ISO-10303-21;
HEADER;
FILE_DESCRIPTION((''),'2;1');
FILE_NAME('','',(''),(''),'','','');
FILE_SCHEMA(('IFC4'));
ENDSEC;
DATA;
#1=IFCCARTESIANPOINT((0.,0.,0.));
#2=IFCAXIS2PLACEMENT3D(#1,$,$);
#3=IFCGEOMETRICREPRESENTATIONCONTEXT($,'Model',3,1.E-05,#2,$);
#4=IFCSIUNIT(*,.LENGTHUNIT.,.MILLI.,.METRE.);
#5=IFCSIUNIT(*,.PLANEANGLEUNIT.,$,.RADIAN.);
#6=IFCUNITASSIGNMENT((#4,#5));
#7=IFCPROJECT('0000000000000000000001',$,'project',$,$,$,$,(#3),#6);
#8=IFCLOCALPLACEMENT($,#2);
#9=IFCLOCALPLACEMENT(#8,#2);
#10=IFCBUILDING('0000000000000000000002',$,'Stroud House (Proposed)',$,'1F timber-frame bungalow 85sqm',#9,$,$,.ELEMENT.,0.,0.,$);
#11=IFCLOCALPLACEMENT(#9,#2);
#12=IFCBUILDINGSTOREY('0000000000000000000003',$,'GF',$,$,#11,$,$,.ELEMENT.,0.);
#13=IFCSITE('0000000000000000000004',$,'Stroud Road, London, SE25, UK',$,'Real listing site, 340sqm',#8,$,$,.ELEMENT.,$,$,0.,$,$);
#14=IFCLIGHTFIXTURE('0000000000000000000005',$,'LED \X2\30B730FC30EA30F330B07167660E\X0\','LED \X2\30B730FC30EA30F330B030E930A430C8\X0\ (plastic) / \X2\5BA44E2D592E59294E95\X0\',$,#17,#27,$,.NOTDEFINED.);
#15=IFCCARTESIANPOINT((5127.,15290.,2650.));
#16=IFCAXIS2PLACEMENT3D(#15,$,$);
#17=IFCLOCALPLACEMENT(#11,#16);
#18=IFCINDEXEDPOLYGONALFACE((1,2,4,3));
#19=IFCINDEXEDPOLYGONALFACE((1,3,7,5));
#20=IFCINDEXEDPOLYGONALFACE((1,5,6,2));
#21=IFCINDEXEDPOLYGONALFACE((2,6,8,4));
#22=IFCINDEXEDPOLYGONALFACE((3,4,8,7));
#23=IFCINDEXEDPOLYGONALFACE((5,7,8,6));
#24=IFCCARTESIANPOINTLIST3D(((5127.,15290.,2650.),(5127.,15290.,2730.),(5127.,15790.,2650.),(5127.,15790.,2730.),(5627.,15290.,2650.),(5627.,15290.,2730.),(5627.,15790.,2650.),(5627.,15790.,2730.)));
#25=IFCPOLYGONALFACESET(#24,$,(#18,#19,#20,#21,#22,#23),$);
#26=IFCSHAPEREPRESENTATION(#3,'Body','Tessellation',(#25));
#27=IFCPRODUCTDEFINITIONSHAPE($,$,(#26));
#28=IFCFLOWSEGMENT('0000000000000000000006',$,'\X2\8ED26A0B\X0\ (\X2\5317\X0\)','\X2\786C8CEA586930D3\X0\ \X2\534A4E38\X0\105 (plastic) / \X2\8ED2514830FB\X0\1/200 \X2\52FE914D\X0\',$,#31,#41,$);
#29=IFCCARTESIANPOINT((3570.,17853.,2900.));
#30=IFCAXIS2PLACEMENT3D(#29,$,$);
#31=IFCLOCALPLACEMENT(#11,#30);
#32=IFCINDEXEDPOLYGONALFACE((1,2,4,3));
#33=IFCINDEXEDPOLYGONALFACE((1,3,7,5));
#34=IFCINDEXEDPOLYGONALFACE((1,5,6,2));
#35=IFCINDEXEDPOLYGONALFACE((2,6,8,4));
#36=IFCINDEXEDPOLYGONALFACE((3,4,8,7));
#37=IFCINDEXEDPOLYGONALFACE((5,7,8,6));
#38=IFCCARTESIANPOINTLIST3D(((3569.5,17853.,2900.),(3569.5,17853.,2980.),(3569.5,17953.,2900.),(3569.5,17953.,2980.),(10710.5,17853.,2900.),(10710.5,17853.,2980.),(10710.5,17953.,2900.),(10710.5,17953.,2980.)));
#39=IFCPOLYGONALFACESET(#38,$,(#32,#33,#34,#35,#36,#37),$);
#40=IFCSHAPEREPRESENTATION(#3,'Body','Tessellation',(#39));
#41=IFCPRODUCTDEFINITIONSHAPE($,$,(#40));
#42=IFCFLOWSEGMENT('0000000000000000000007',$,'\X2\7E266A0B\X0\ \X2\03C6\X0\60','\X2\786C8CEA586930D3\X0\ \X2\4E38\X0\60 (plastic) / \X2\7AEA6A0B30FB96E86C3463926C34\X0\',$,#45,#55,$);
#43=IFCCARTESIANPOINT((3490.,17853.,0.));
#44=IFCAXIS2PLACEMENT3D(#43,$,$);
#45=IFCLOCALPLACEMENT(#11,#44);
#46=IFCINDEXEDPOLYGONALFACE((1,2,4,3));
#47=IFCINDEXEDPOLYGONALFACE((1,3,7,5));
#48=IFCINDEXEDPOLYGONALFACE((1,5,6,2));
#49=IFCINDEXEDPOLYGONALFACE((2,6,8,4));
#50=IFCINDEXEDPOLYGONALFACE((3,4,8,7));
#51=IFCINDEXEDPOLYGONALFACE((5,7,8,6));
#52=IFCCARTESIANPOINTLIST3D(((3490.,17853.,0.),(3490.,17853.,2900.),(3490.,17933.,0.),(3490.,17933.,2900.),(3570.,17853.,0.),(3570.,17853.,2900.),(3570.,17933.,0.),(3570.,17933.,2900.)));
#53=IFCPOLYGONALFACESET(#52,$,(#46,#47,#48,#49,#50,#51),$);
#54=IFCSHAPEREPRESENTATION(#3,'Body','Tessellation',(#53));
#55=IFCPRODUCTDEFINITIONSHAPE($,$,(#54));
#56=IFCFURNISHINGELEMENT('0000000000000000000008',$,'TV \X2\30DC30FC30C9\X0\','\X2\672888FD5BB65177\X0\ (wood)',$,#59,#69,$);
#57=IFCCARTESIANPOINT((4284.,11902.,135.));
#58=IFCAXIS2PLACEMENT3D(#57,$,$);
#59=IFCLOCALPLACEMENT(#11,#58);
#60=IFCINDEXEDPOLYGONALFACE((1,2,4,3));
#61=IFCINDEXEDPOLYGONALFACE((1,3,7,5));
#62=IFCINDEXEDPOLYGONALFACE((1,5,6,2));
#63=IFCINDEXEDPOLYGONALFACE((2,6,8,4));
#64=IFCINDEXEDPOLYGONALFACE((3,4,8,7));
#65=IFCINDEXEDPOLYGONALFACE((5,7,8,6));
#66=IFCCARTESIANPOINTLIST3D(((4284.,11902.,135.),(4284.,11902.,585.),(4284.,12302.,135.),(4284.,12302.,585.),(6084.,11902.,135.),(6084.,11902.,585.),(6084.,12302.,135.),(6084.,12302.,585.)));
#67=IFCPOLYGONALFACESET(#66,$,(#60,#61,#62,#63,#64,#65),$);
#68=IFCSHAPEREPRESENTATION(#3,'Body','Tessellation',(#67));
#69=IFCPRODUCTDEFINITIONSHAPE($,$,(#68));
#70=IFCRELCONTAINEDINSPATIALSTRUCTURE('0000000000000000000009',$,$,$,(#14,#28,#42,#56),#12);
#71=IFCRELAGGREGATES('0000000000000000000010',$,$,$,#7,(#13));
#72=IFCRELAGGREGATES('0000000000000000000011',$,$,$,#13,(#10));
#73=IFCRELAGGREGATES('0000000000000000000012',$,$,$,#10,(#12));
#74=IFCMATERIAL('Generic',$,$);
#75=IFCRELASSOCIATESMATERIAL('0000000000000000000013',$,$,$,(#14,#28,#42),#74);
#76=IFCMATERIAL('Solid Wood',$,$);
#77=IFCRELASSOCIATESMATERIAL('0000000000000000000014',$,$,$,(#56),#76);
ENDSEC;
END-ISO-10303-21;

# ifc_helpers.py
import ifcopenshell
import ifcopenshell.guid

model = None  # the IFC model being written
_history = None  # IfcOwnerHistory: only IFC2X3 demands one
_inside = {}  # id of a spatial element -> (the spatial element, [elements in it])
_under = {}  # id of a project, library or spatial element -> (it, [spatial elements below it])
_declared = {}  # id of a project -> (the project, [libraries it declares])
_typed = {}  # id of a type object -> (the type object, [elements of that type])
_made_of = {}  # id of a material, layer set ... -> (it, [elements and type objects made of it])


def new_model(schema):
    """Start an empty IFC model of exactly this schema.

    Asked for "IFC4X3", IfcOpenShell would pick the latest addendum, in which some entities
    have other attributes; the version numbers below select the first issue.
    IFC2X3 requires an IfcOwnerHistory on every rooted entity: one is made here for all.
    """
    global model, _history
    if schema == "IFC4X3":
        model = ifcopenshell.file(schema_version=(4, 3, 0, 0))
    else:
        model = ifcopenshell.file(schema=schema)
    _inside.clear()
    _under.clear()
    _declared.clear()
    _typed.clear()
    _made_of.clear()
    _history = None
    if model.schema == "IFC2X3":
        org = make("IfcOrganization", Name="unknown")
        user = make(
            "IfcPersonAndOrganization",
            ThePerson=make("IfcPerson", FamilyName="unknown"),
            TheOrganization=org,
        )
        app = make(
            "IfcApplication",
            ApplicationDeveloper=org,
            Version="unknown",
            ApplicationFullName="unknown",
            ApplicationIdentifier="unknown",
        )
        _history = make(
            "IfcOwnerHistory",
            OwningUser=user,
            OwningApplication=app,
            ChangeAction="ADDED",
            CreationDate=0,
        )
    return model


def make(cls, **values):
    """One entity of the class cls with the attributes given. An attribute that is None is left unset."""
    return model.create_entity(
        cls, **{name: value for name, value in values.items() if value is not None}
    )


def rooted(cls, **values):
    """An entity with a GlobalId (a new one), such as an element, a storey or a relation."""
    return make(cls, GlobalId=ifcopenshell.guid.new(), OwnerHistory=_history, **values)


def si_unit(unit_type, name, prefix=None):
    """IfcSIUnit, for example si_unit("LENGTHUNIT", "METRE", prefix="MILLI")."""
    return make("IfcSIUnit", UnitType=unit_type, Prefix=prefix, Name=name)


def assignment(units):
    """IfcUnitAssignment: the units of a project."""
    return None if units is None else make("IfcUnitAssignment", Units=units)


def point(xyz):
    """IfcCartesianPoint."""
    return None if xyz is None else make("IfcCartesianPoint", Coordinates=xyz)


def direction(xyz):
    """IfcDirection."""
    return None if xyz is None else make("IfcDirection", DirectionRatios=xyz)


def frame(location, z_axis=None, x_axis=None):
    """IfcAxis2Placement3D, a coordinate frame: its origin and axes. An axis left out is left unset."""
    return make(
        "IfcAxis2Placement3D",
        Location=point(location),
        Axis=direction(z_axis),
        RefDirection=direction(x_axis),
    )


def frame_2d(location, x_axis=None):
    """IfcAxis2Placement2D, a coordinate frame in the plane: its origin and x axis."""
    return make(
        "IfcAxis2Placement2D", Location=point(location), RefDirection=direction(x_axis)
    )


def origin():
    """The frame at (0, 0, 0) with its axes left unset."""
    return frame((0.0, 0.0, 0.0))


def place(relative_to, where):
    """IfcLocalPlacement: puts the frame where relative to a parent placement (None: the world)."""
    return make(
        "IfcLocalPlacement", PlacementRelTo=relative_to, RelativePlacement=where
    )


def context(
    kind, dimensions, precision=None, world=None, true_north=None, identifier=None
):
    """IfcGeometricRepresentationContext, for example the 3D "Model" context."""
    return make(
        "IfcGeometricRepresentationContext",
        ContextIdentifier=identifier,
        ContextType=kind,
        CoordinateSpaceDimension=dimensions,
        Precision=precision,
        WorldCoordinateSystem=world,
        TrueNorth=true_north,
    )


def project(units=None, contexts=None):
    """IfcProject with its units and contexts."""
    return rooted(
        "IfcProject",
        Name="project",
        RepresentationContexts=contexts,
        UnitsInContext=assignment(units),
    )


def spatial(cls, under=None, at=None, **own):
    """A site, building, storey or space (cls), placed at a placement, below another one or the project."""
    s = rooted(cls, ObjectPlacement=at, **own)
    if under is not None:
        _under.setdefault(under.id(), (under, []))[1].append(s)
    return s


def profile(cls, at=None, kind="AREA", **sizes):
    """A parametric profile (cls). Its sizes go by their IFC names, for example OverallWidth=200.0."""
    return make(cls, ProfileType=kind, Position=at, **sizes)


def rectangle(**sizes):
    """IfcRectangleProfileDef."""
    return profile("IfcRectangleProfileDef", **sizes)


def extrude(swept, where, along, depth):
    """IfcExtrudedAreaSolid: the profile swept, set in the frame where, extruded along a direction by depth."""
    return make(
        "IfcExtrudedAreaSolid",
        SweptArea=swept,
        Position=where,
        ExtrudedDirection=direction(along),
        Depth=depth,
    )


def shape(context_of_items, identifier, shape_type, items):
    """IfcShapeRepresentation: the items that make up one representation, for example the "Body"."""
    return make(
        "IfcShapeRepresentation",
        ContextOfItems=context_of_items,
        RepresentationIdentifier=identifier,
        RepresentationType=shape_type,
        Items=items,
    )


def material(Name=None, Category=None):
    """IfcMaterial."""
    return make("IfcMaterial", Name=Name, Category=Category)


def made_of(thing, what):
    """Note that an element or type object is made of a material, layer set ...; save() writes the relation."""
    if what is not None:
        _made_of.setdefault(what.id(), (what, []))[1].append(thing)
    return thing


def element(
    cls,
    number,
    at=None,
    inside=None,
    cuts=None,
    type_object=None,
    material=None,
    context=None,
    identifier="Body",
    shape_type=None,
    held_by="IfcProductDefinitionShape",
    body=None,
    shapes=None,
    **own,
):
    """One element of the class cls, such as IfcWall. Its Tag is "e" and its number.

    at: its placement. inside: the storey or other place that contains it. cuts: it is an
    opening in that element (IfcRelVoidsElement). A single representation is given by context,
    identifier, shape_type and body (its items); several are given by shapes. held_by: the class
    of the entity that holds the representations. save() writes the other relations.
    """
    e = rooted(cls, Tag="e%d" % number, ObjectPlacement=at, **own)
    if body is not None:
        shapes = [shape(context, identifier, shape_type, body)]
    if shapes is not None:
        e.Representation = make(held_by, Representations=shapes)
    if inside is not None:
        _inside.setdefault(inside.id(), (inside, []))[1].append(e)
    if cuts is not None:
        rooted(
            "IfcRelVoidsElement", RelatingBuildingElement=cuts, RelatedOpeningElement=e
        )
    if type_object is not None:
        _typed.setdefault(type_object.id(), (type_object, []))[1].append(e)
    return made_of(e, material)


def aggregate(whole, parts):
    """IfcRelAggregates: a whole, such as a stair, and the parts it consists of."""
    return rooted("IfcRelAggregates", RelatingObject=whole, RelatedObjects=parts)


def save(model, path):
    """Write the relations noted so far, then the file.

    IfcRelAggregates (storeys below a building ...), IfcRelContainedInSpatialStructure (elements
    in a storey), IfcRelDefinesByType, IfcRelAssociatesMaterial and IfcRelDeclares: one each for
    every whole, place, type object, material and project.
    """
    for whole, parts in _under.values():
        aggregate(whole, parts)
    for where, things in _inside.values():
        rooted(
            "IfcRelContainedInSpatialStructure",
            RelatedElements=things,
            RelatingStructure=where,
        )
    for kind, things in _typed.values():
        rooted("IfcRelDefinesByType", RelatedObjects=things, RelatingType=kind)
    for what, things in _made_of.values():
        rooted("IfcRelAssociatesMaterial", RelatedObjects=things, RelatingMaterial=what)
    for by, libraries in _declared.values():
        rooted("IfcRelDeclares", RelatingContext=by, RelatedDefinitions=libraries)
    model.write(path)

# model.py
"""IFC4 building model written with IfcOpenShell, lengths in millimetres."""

from ifc_helpers import new_model, si_unit, frame, frame_2d, origin, place, context, project, spatial, rectangle, extrude, material, element, save


model = new_model("IFC4")

# Units and contexts
model_context = context("Model", 3, precision=1e-05, world=origin())
ifc_project = project(units=[si_unit("LENGTHUNIT", "METRE", prefix="MILLI"), si_unit("PLANEANGLEUNIT", "RADIAN")], contexts=[model_context])

# Site, building, storey
site_placement = place(None, origin())
site = spatial("IfcSite", under=ifc_project, at=site_placement, Name="Stroud Road, London, SE25, UK", ObjectType="Real listing site, 340sqm", CompositionType="ELEMENT", RefElevation=0.0)
building_placement = place(site_placement, origin())
building = spatial("IfcBuilding", under=site, at=building_placement, Name="Stroud House (Proposed)", ObjectType="1F timber-frame bungalow 85sqm", CompositionType="ELEMENT", ElevationOfRefHeight=0.0, ElevationOfTerrain=0.0)
storey_placement = place(building_placement, origin())
storey = spatial("IfcBuildingStorey", under=building, at=storey_placement, Name="GF", CompositionType="ELEMENT", Elevation=0.0)

# Shared definitions
ifc_material_1 = material(Name="Solid Wood")

# Shared definitions
ifc_material_2 = material(Name="Generic")

# Light fixture
light_fixture_placement = place(storey_placement, frame((5127.0, 15290.0, 2650.0)))
element("IfcLightFixture", 1, at=light_fixture_placement, inside=storey, material=ifc_material_2, Name="LED シーリング照明", Description="LED シーリングライト (plastic) / 室中央天井", PredefinedType="NOTDEFINED", context=model_context, shape_type="SweptSolid", body=[
    extrude(rectangle(XDim=500.0, YDim=500.0, at=frame_2d((250.0, 250.0))), frame((5127.0, 15290.0, 2650.0)), (0.0, 0.0, 1.0), 80.0),
])

# Flow segments
flow_segment_1_placement = place(storey_placement, frame((3570.0, 17853.0, 2900.0)))
element("IfcFlowSegment", 2, at=flow_segment_1_placement, inside=storey, material=ifc_material_2, Name="軒樋 (北)", Description="硬質塩ビ 半丸105 (plastic) / 軒先・1/200 勾配", context=model_context, shape_type="SweptSolid", body=[
    extrude(rectangle(XDim=7141.0, YDim=100.0, at=frame_2d((3570.0, 50.0))), frame((3570.0, 17853.0, 2900.0)), (0.0, 0.0, 1.0), 80.0),
])
flow_segment_2_placement = place(storey_placement, frame((3490.0, 17853.0, 0.0)))
element("IfcFlowSegment", 3, at=flow_segment_2_placement, inside=storey, material=ifc_material_2, Name="縦樋 φ60", Description="硬質塩ビ 丸60 (plastic) / 竪樋・雨水排水", context=model_context, shape_type="SweptSolid", body=[
    extrude(rectangle(XDim=80.0, YDim=80.0, at=frame_2d((40.0, 40.0))), frame((3490.0, 17853.0, 0.0)), (0.0, 0.0, 1.0), 2900.0),
])

# Furnishing element
furnishing_placement = place(storey_placement, frame((4284.0, 11902.0, 135.0)))
element("IfcFurnishingElement", 4, at=furnishing_placement, inside=storey, material=ifc_material_1, Name="TV ボード", Description="木製家具 (wood)", context=model_context, shape_type="SweptSolid", body=[
    extrude(rectangle(XDim=1800.0, YDim=400.0, at=frame_2d((900.0, 200.0))), frame((4284.0, 11902.0, 135.0)), (0.0, 0.0, 1.0), 450.0),
])

save(model, "model.ifc")
